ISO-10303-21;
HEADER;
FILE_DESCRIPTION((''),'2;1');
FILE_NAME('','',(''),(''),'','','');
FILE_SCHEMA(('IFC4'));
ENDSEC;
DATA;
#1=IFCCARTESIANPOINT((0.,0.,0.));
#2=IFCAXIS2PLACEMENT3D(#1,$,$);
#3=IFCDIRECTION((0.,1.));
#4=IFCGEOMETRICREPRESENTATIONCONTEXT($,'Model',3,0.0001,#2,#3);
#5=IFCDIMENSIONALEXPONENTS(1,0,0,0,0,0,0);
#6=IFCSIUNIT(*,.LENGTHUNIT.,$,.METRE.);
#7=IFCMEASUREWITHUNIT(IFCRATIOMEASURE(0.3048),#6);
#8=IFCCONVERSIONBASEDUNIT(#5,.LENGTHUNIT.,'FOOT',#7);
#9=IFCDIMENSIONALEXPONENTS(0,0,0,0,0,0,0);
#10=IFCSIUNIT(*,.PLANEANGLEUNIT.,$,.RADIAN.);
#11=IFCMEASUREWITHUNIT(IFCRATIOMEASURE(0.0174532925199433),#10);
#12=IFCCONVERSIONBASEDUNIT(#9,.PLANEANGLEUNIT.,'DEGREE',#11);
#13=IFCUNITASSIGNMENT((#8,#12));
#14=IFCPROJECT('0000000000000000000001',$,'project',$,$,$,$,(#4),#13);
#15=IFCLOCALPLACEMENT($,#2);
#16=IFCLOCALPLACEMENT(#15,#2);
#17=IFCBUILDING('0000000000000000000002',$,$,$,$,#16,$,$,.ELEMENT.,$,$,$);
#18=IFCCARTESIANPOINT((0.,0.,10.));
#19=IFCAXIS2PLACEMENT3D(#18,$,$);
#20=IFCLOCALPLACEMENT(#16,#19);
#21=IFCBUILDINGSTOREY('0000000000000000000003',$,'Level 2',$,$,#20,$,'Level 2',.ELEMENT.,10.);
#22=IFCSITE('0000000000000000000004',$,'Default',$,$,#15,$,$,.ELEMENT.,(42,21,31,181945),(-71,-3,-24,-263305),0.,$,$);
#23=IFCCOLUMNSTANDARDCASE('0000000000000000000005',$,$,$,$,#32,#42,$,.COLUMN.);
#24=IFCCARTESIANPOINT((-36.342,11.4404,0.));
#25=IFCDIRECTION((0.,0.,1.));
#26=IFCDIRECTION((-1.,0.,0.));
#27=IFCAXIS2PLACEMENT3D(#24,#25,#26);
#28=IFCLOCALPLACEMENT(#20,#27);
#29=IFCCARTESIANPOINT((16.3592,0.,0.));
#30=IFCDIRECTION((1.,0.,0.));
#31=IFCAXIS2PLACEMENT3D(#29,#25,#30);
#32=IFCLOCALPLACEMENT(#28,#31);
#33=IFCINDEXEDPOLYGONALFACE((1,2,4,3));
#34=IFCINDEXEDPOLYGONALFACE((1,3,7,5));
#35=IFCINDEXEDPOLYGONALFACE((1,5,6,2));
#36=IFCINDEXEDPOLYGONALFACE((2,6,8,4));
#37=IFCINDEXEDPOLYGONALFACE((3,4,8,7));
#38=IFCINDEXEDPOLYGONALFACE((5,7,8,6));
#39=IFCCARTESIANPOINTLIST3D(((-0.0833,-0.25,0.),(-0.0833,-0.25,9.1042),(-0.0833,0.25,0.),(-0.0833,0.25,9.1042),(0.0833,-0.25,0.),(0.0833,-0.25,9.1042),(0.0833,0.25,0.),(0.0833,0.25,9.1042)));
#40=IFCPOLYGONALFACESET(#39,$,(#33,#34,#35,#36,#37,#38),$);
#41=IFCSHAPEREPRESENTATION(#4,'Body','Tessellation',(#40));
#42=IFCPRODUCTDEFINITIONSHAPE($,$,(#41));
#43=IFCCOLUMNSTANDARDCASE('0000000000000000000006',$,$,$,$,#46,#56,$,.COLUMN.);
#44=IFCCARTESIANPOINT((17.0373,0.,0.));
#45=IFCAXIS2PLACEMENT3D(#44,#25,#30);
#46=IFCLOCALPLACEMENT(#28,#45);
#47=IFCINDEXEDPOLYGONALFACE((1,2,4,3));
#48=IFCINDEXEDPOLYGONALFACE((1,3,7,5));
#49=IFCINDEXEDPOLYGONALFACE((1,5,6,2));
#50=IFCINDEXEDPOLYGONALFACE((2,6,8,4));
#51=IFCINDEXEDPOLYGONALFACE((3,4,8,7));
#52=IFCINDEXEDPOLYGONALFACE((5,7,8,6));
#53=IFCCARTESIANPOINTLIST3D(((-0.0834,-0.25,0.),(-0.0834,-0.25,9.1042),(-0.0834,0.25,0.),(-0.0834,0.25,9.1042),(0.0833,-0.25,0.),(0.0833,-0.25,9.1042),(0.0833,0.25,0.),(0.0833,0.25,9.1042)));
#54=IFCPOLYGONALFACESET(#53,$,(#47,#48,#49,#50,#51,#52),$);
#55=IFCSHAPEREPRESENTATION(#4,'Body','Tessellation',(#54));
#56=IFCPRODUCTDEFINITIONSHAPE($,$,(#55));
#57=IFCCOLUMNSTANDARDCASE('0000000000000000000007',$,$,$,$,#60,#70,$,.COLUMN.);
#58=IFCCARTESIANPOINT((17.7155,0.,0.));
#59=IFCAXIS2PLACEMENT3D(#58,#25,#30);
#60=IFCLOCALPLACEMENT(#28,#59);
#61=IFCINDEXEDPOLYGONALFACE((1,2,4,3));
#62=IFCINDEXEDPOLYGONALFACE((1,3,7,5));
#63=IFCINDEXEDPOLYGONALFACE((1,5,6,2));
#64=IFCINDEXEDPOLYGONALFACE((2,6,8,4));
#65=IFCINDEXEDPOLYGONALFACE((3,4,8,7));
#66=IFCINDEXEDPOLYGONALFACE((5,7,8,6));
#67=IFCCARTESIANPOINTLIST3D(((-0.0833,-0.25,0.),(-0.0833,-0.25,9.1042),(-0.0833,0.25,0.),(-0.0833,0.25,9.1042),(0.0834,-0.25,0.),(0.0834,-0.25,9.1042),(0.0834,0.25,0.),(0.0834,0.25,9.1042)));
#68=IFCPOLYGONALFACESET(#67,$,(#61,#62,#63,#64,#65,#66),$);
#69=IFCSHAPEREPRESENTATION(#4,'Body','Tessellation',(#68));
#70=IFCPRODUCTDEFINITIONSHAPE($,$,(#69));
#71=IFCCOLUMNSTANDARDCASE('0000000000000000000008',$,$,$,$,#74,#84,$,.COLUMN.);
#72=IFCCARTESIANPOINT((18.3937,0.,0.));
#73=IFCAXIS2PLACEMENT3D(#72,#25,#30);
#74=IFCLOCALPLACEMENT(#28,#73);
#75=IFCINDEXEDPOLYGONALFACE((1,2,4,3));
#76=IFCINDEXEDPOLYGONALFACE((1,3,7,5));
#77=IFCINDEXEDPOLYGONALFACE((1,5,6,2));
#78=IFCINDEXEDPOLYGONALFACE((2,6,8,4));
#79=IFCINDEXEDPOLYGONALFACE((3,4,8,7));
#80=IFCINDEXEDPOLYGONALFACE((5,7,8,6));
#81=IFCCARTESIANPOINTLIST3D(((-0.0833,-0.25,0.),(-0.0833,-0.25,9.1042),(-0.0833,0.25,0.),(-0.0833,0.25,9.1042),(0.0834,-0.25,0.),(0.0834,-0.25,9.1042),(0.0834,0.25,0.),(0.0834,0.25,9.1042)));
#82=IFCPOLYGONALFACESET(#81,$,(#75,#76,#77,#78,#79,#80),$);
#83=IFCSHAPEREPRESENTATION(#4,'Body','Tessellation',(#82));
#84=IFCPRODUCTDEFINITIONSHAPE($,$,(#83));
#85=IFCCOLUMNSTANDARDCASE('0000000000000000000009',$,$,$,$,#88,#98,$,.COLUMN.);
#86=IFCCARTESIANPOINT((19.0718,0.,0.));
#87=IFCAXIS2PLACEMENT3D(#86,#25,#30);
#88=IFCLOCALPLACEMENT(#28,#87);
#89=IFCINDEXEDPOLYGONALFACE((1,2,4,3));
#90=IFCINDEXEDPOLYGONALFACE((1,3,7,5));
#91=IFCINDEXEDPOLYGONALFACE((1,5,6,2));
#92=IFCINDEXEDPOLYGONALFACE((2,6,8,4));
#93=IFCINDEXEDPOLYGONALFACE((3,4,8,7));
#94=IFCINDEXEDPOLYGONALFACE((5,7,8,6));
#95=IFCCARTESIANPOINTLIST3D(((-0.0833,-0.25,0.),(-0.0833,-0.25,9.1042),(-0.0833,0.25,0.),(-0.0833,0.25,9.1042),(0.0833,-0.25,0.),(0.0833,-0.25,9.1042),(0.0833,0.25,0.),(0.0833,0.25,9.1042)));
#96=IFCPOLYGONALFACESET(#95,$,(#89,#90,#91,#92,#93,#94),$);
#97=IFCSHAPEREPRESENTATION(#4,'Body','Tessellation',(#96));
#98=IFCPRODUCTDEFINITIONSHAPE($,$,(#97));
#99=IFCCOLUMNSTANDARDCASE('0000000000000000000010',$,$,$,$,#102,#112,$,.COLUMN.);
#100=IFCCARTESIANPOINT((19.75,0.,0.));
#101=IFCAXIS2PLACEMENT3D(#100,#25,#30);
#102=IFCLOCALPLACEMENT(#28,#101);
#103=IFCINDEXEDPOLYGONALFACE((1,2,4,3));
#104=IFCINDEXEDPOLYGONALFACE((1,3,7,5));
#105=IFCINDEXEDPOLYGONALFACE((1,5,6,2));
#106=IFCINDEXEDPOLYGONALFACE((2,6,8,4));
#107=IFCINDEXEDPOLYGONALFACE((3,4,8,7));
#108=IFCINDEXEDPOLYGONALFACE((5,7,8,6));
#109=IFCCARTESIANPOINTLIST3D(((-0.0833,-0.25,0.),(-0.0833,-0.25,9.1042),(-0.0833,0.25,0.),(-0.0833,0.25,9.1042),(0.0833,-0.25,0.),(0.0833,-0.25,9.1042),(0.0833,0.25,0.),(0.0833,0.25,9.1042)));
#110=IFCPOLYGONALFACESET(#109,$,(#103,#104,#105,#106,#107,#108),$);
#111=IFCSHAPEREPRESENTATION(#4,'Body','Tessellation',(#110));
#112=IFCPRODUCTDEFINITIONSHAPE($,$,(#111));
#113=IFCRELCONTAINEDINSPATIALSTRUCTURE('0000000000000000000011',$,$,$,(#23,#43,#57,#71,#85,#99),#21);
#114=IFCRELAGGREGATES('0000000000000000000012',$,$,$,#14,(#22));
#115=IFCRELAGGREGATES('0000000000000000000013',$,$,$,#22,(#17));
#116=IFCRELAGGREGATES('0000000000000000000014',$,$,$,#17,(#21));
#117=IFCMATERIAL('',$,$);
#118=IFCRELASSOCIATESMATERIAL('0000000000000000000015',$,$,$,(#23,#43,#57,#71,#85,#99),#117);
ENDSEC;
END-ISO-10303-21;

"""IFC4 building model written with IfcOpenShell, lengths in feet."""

from ifc_helpers import new_model, entity, si_unit, converted_unit, direction, frame, origin, place, context, project, spatial, rectangle, extrude, material, element, save


model = new_model("IFC4")

# Units and contexts
model_context = context("Model", 3, precision=0.0001, world=origin(), true_north=direction((0.0, 1.0)))
ifc_project = project(units=[converted_unit("LENGTHUNIT", "FOOT", entity("IfcRatioMeasure", 0.3048), si_unit("LENGTHUNIT", "METRE"), dimensions=[1, 0, 0, 0, 0, 0, 0]), converted_unit("PLANEANGLEUNIT", "DEGREE", entity("IfcRatioMeasure", 0.0174532925199433), si_unit("PLANEANGLEUNIT", "RADIAN"), dimensions=[0, 0, 0, 0, 0, 0, 0])], contexts=[model_context])

# Site, building, storey
site_placement = place(None, origin())
site = spatial("IfcSite", under=ifc_project, at=site_placement, Name="Default", CompositionType="ELEMENT", RefLatitude=(42, 21, 31, 181945), RefLongitude=(-71, -3, -24, -263305), RefElevation=0.0)
building_placement = place(site_placement, origin())
building = spatial("IfcBuilding", under=site, at=building_placement, CompositionType="ELEMENT")
storey_placement = place(building_placement, frame((0.0, 0.0, 10.0)))
storey = spatial("IfcBuildingStorey", under=building, at=storey_placement, Name="Level 2", LongName="Level 2", CompositionType="ELEMENT", Elevation=10.0)

# Columns
ifc_material_1 = material(Name="")
placement_1 = place(storey_placement, frame((-36.342, 11.4404, 0.0), z_axis=(0.0, 0.0, 1.0), x_axis=(-1.0, 0.0, 0.0)))
for number, where, z_axis, x_axis in (
    (1, (16.3592, 0.0, 0.0), (0.0, 0.0, 1.0), (1.0, 0.0, 0.0)),
    (2, (17.0373, 0.0, 0.0), (0.0, 0.0, 1.0), (1.0, 0.0, 0.0)),
    (3, (17.7155, 0.0, 0.0), (0.0, 0.0, 1.0), (1.0, 0.0, 0.0)),
    (4, (18.3937, 0.0, 0.0), (0.0, 0.0, 1.0), (1.0, 0.0, 0.0)),
    (5, (19.0718, 0.0, 0.0), (0.0, 0.0, 1.0), (1.0, 0.0, 0.0)),
    (6, (19.75, 0.0, 0.0), (0.0, 0.0, 1.0), (1.0, 0.0, 0.0)),
):
    element("IfcColumnStandardCase", number, at=place(placement_1, frame(where, z_axis=z_axis, x_axis=x_axis)), inside=storey, material=ifc_material_1, PredefinedType="COLUMN", context=model_context, shape_type="SweptSolid", body=[
        extrude(rectangle(XDim=0.1667, YDim=0.5), origin(), (0.0, 0.0, 1.0), 9.1042),
    ])

save(model, "model.ifc")
